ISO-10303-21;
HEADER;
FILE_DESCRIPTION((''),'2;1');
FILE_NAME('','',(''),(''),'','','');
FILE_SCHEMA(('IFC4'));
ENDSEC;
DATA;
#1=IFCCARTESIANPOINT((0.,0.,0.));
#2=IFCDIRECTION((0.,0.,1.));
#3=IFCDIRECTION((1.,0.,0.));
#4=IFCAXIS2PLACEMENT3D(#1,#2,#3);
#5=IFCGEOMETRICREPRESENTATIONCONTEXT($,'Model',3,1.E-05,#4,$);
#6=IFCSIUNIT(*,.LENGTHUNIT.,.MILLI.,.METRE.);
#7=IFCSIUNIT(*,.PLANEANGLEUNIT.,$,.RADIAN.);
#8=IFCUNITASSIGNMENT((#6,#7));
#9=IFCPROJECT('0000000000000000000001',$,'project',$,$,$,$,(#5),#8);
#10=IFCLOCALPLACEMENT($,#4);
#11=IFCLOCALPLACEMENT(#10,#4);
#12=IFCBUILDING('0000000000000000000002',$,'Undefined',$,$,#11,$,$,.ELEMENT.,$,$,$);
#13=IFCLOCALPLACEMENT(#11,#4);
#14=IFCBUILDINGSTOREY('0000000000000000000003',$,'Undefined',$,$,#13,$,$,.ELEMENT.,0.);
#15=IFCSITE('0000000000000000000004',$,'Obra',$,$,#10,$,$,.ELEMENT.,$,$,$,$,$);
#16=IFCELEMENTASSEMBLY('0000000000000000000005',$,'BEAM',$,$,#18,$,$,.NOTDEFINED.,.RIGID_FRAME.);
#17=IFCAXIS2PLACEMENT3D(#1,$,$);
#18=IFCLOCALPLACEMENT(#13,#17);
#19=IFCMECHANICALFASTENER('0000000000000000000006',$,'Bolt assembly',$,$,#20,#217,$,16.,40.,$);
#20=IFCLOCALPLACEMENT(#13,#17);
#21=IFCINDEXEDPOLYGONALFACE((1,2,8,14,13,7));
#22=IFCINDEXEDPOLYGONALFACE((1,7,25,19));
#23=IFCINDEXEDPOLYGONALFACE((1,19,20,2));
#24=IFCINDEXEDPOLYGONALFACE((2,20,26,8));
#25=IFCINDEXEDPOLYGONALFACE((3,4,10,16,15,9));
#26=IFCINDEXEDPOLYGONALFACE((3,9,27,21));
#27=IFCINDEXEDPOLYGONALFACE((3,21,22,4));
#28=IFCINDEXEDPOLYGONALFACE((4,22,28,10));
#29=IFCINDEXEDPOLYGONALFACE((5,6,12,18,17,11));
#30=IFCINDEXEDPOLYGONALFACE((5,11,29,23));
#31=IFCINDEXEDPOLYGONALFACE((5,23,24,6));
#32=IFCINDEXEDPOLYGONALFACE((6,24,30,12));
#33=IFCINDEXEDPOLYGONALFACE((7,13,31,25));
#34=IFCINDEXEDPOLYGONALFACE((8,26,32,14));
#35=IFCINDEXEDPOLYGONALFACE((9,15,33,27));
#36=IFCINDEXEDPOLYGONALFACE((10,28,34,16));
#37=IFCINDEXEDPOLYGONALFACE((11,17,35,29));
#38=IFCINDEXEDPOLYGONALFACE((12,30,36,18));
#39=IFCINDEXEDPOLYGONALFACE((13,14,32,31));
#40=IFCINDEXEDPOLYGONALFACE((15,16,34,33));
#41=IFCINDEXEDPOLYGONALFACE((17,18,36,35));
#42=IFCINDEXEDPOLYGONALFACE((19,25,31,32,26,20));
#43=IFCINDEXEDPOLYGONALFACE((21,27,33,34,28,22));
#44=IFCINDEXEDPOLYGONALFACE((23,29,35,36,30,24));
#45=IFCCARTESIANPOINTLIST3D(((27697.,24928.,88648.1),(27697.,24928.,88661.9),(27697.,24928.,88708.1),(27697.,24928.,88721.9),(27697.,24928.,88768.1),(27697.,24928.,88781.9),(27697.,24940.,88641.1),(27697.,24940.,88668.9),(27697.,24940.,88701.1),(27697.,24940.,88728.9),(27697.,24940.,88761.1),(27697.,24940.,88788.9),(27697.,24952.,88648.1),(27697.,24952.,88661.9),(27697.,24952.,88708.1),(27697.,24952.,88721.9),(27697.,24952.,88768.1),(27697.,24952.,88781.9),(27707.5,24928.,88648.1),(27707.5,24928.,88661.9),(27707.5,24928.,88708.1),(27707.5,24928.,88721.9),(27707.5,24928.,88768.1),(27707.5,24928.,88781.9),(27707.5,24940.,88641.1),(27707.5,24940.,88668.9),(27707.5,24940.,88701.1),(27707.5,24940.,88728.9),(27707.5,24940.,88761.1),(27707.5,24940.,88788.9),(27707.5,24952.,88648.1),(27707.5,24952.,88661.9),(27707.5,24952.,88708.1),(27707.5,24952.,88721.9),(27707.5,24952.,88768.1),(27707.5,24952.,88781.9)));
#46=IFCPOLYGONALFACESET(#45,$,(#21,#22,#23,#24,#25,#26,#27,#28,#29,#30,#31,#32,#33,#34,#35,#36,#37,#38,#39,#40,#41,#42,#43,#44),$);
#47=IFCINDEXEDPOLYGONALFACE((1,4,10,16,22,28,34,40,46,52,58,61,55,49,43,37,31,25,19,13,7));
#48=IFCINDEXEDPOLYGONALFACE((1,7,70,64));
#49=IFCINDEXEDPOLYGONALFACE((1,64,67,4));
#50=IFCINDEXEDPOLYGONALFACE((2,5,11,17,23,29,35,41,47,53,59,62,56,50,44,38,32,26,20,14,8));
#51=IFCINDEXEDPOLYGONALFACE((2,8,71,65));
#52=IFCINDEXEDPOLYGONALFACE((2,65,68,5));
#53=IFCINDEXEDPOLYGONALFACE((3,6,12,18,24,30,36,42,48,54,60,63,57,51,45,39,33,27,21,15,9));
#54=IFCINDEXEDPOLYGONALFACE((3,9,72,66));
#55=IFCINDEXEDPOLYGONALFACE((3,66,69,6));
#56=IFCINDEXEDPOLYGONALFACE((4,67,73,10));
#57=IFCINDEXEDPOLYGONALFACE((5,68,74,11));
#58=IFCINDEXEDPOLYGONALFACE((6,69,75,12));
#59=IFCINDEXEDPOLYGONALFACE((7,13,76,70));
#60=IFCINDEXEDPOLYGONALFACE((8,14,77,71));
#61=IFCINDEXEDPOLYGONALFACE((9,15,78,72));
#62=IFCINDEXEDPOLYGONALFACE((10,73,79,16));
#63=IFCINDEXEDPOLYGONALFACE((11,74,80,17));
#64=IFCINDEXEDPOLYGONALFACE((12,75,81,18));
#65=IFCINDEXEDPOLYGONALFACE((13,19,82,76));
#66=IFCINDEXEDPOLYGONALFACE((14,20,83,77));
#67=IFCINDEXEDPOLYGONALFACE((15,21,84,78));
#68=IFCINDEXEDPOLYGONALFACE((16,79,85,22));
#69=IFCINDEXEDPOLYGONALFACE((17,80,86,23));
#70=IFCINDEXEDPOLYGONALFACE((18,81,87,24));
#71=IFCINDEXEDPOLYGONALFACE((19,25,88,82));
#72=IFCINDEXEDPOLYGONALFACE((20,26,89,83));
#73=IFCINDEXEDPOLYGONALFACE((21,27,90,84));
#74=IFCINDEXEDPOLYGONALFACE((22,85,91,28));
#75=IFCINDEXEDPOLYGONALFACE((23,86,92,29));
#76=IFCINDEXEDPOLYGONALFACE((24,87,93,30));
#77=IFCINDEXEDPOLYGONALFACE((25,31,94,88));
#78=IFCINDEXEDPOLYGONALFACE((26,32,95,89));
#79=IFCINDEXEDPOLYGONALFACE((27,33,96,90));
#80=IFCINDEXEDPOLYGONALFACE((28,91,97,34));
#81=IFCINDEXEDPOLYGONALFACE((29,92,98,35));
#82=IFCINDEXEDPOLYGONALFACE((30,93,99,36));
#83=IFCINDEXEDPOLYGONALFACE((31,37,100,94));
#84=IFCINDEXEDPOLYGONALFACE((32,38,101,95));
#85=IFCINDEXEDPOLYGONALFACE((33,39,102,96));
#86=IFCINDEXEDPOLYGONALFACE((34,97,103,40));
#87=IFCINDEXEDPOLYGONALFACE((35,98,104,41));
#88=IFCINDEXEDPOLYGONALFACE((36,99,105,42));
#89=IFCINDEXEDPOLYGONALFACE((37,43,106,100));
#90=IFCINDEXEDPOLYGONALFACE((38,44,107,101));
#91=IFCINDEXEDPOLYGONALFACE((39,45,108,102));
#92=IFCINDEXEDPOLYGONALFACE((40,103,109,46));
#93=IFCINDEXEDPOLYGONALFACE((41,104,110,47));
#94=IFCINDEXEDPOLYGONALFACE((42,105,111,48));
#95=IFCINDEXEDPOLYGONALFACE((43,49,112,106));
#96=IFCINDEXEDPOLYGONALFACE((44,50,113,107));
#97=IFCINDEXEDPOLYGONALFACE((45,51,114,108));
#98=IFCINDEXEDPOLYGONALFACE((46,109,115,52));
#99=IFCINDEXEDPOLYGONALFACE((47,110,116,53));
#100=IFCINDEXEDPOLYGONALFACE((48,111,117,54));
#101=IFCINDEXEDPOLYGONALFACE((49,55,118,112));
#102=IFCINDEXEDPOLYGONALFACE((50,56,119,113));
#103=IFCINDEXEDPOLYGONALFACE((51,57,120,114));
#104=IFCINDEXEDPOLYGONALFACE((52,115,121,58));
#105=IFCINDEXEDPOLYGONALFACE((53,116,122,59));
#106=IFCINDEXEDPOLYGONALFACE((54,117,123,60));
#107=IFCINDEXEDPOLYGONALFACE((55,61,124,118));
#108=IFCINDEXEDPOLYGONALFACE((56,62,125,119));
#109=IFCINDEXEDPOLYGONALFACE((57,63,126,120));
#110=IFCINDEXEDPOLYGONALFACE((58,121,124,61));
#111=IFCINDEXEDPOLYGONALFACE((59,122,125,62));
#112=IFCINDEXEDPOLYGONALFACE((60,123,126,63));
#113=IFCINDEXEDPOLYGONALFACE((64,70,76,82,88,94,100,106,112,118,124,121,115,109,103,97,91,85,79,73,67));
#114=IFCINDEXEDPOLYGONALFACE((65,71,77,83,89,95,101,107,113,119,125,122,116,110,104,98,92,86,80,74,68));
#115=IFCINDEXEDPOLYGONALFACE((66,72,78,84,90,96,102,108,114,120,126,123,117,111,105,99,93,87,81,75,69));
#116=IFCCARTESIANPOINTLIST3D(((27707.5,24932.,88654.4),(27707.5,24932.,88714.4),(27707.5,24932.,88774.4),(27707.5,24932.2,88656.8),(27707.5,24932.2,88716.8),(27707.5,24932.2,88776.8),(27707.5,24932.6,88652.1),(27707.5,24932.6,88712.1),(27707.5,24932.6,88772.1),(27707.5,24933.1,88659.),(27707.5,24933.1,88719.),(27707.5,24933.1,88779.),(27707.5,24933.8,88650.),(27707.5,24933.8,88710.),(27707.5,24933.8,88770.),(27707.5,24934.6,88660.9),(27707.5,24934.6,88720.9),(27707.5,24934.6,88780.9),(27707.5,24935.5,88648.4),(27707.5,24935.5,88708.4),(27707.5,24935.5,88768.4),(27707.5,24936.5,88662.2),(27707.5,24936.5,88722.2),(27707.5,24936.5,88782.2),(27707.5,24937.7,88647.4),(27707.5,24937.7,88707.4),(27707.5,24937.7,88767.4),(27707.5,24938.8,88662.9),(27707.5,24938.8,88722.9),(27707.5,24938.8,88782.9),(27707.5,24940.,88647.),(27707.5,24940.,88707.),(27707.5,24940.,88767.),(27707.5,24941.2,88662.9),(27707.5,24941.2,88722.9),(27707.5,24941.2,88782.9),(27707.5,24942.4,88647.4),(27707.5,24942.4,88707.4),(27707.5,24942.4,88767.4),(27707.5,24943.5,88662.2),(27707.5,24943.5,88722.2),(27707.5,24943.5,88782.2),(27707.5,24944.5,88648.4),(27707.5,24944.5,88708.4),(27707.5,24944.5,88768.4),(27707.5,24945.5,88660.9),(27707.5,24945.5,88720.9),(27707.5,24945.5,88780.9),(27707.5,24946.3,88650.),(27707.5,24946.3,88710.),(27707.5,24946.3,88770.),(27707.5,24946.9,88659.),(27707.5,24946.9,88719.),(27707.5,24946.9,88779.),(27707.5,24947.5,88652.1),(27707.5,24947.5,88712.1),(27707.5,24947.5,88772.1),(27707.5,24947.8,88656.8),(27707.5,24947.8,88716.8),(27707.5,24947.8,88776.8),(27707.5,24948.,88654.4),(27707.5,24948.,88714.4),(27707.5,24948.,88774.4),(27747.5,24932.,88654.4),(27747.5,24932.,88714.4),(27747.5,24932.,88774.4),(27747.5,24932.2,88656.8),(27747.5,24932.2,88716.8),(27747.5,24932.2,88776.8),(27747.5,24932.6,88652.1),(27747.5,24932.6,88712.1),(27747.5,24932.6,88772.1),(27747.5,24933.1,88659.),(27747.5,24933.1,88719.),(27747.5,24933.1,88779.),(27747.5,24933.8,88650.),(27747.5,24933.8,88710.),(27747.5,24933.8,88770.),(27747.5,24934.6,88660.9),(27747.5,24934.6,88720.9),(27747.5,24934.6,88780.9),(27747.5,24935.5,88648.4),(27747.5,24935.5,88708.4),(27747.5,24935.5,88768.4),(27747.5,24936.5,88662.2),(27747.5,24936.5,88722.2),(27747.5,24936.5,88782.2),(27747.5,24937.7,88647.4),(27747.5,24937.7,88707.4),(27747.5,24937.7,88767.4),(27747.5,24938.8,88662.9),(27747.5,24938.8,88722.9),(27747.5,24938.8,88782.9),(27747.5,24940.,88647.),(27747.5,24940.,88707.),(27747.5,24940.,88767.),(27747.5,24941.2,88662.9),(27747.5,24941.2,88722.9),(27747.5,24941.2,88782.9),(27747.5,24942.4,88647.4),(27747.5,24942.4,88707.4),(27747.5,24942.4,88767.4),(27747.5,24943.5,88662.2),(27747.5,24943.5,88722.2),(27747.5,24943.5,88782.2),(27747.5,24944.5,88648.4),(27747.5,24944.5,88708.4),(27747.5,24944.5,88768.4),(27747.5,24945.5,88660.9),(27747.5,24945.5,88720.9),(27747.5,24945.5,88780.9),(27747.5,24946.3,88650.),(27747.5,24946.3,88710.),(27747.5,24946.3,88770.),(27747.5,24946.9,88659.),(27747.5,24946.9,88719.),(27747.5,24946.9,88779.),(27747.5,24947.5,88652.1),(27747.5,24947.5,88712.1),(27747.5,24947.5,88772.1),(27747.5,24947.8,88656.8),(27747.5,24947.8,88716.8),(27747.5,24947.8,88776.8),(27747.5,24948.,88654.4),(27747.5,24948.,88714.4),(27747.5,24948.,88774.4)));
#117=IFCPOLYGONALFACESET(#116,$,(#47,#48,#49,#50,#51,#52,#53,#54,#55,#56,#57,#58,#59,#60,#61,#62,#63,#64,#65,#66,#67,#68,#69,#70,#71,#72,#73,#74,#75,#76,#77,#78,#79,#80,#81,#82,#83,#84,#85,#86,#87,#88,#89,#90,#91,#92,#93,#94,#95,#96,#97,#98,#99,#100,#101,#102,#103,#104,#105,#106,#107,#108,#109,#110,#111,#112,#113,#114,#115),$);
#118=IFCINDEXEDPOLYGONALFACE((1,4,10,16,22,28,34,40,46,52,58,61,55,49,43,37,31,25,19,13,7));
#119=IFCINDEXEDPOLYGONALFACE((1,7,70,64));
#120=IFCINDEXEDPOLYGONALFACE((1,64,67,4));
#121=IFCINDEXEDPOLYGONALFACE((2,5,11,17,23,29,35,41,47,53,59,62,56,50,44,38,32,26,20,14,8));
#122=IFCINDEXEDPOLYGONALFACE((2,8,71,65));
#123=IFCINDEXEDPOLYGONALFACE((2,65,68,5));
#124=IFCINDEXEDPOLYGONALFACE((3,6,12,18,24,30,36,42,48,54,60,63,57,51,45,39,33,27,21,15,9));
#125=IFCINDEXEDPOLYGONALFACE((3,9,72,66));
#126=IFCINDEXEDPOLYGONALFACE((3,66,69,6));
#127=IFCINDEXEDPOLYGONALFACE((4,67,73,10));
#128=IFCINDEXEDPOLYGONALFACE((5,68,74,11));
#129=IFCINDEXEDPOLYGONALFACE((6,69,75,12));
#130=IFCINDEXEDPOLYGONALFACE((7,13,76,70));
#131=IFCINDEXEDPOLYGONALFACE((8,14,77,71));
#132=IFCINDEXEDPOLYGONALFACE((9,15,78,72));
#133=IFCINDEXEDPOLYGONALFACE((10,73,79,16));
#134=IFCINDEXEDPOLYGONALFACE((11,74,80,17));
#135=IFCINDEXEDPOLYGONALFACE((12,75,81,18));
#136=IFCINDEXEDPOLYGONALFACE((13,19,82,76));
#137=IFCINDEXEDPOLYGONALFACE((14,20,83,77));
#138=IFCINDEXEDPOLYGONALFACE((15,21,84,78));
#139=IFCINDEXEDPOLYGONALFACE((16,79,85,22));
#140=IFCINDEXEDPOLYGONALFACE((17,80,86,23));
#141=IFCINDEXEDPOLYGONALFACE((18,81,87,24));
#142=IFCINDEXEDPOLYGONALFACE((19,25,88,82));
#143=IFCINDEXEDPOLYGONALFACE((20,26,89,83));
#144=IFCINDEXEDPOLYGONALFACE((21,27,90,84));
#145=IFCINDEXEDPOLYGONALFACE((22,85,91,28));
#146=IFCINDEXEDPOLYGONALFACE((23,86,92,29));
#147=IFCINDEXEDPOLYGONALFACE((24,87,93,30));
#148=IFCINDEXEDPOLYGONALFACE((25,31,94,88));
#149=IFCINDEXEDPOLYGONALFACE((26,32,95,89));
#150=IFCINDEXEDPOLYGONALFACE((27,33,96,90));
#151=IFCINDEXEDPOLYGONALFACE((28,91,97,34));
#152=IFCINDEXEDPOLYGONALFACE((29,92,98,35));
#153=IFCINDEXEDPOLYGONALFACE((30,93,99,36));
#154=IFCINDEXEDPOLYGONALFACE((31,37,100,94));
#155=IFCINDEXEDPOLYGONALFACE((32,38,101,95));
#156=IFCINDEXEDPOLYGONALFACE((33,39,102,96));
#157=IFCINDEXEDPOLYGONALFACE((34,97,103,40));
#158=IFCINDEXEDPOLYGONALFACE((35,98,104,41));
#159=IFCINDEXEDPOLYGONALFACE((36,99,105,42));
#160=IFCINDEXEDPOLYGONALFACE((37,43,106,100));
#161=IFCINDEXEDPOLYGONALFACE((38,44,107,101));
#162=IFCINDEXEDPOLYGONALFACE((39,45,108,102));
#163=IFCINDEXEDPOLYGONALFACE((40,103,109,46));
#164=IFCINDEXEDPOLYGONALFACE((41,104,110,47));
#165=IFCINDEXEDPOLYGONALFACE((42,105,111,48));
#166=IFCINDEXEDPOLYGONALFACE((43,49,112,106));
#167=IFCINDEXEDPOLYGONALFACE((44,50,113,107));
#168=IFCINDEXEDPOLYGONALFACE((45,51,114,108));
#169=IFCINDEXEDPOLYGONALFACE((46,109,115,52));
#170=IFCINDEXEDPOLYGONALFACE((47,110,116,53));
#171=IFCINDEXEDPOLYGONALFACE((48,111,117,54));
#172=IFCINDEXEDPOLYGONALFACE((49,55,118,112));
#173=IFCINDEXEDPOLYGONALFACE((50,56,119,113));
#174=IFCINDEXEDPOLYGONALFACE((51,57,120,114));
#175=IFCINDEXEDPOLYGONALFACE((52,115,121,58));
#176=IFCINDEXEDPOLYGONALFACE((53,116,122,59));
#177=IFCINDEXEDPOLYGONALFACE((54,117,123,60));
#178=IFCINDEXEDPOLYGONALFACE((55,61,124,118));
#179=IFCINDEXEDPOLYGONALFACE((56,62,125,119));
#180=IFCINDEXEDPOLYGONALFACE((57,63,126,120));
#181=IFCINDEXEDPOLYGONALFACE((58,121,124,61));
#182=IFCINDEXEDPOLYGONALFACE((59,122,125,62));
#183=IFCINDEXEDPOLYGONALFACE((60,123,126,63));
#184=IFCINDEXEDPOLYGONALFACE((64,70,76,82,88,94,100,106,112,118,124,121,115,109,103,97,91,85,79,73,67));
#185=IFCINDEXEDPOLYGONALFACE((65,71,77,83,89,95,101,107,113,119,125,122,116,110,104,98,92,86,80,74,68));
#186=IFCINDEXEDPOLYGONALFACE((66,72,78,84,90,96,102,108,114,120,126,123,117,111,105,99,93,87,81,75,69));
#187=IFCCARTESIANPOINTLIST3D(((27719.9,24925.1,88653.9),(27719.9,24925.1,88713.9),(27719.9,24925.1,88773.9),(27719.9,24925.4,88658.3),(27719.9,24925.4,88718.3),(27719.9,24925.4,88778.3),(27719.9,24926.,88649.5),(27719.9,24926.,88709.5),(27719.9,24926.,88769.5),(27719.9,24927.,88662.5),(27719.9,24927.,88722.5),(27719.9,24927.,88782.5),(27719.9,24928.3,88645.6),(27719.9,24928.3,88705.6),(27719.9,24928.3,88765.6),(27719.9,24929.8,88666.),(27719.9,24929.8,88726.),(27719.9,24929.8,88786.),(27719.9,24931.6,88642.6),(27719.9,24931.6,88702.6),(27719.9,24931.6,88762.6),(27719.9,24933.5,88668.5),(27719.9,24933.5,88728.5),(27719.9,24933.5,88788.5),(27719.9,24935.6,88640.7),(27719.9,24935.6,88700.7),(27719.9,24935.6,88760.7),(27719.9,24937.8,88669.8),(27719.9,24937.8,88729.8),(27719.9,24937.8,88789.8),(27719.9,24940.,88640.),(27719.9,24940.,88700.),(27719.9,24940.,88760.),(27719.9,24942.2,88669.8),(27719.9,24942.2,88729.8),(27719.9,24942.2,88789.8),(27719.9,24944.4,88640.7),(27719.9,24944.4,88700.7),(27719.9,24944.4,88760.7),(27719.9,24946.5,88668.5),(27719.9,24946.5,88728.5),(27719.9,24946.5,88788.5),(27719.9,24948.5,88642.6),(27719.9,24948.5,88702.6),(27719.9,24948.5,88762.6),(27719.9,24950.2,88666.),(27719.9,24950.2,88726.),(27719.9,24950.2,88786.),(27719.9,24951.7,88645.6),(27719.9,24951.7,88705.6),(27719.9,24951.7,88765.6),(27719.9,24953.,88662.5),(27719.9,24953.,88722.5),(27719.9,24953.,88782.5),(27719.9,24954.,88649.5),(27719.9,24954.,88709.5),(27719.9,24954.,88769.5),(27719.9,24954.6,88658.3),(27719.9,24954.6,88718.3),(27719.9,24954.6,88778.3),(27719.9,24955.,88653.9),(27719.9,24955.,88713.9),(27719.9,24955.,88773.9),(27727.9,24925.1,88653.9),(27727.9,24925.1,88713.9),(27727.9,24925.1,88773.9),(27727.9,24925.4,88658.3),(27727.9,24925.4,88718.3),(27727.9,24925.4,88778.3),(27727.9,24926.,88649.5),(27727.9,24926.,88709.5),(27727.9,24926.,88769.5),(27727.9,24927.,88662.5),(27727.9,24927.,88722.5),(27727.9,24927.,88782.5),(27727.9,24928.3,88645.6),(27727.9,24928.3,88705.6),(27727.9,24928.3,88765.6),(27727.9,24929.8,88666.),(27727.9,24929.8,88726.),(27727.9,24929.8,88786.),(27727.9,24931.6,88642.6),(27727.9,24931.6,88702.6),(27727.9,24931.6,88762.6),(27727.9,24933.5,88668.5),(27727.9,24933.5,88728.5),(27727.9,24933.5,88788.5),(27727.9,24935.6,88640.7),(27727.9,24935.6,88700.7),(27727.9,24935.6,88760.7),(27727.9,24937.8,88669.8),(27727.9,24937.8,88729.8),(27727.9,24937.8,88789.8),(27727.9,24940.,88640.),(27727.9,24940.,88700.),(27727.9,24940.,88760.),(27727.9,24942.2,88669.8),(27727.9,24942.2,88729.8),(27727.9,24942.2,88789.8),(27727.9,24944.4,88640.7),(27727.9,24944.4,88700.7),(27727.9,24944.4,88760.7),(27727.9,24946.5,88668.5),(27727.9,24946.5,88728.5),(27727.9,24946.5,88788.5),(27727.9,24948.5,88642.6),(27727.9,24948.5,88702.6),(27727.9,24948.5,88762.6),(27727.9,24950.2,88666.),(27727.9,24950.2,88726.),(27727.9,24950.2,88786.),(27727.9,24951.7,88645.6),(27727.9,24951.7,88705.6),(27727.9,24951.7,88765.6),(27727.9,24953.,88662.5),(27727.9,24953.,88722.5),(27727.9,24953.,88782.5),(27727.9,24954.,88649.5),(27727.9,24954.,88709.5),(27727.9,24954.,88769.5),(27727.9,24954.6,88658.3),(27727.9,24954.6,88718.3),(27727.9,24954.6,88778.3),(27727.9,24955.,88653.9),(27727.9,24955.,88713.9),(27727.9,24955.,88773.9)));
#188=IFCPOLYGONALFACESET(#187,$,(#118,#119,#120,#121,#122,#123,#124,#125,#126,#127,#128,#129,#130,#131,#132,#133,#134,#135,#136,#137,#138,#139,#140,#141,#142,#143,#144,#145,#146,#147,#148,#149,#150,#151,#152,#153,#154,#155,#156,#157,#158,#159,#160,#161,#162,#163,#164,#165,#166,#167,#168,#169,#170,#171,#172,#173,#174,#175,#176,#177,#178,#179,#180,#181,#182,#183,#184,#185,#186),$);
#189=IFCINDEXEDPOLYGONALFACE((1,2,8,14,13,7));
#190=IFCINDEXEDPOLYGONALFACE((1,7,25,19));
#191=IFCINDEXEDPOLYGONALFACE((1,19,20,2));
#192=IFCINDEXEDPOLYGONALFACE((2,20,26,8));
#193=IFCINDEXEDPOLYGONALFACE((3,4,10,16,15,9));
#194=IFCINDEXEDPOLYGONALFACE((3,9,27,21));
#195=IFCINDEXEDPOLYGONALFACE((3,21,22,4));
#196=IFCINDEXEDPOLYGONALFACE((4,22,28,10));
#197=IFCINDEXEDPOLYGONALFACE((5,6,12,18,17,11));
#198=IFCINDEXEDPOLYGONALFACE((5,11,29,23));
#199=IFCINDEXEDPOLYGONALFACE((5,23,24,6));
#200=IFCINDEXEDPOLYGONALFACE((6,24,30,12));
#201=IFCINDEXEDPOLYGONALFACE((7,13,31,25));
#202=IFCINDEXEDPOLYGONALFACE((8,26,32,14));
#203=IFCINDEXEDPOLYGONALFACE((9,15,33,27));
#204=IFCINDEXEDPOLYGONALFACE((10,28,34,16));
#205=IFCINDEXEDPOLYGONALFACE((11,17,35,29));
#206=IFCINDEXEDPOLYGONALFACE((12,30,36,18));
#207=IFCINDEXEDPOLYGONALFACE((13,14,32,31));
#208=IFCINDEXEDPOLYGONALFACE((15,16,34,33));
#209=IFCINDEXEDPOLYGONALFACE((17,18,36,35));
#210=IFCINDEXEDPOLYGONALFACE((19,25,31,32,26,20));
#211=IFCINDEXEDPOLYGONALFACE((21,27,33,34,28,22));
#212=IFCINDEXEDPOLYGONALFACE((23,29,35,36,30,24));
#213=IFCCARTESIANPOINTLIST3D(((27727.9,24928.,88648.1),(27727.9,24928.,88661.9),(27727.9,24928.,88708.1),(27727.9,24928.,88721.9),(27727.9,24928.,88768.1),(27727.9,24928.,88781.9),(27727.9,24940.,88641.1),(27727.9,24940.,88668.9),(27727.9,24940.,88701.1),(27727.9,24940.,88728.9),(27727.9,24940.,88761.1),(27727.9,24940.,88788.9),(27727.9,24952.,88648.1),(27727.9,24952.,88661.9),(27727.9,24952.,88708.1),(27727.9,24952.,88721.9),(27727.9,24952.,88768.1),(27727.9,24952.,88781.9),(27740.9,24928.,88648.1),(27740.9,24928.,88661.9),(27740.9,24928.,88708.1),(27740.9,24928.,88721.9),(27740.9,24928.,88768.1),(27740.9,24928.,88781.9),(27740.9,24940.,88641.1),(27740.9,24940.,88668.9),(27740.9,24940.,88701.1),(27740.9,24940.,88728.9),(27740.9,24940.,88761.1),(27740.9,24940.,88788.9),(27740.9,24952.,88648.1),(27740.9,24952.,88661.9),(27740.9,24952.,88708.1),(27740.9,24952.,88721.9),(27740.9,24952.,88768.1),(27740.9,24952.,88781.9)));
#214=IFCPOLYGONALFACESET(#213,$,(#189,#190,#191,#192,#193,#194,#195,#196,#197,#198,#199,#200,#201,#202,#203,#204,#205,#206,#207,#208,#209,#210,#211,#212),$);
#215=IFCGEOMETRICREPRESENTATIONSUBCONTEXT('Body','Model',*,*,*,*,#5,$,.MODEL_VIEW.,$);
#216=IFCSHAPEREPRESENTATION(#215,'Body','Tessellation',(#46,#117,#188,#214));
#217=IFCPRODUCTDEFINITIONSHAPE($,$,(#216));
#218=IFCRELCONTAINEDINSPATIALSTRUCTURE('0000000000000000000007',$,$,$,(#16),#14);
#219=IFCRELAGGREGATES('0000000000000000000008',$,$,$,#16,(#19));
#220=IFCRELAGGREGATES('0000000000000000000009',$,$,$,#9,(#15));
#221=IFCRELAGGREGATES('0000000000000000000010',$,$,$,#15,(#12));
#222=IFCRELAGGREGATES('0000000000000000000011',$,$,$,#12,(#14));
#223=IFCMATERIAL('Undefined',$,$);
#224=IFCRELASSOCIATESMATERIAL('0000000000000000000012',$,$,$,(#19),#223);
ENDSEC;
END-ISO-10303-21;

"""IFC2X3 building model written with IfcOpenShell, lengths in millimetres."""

from ifc_helpers import new_model, si_unit, frame, origin_with_axes, origin_2d_with_axis, place, context, subcontext, project, spatial, polyline, circle, outline, extrude, source, transform, mapped, material, element, aggregate, save


model = new_model("IFC2X3")

# Units and contexts
model_context = context("Model", 3, precision=1e-05, world=origin_with_axes())
body_context = subcontext(model_context, "Body", "Model", "MODEL_VIEW")
ifc_project = project(units=[si_unit("LENGTHUNIT", "METRE", prefix="MILLI"), si_unit("PLANEANGLEUNIT", "RADIAN")], contexts=[model_context])

# Site, building, storey
site_placement = place(None, origin_with_axes())
site = spatial("IfcSite", under=ifc_project, at=site_placement, Name="Obra", CompositionType="ELEMENT")
building_placement = place(site_placement, origin_with_axes())
building = spatial("IfcBuilding", under=site, at=building_placement, Name="Undefined", CompositionType="ELEMENT")
storey_placement = place(building_placement, origin_with_axes())
storey = spatial("IfcBuildingStorey", under=building, at=storey_placement, Name="Undefined", CompositionType="ELEMENT", Elevation=0.0)

# Element assembly
ifc_material_1 = material(Name="Undefined")
assembly_1_placement = place(storey_placement, origin_with_axes())
assembly_1 = element("IfcElementAssembly", 1, at=assembly_1_placement, inside=storey, Name="BEAM", AssemblyPlace="NOTDEFINED", PredefinedType="RIGID_FRAME")

# Mechanical fastener
shared_shape_1 = source(origin_with_axes(), body_context, "Body", "SweptSolid", [
    extrude(outline(polyline([(13.9, 0.0), (6.9, 12.0), (-6.9, 12.0), (-13.9, 0.0), (-6.9, -12.0), (6.9, -12.0), (13.9, 0.0)])), frame((0.0, -19.7, 0.0), z_axis=(0.0, 1.0, 0.0), x_axis=(1.0, 0.0, 0.0)), (0.0, 0.0, 1.0), 10.6),
    extrude(circle(Radius=8.0, at=origin_2d_with_axis()), frame((0.0, -9.1, 0.0), z_axis=(0.0, 1.0, 0.0), x_axis=(1.0, 0.0, 0.0)), (0.0, 0.0, 1.0), 40.0),
    extrude(circle(Radius=15.0, at=origin_2d_with_axis()), frame((0.0, 3.3, 0.0), z_axis=(0.0, 1.0, 0.0), x_axis=(1.0, 0.0, 0.0)), (0.0, 0.0, 1.0), 8.0),
    extrude(outline(polyline([(13.9, 0.0), (6.9, 12.0), (-6.9, 12.0), (-13.9, 0.0), (-6.9, -12.0), (6.9, -12.0), (13.9, 0.0)])), frame((0.0, 11.3, 0.0), z_axis=(0.0, 1.0, 0.0), x_axis=(1.0, 0.0, 0.0)), (0.0, 0.0, 1.0), 13.0),
])
mechanical_fastener_1_placement = place(assembly_1_placement, frame((27716.6, 24990.0, 88835.0), z_axis=(0.000002, -1.0, 0.0), x_axis=(0.0, 0.0, -1.0)))
mechanical_fastener_1 = element("IfcMechanicalFastener", 2, at=mechanical_fastener_1_placement, material=ifc_material_1, Name="Bolt assembly", NominalDiameter=16.0, NominalLength=40.0, context=body_context, shape_type="MappedRepresentation", body=[
    mapped(shared_shape_1, transform((60.0, 0.0, 50.0))),
    mapped(shared_shape_1, transform((120.0, 0.0, 50.0))),
    mapped(shared_shape_1, transform((180.0, 0.0, 50.0))),
])
aggregate(assembly_1, [mechanical_fastener_1])

save(model, "model.ifc")
